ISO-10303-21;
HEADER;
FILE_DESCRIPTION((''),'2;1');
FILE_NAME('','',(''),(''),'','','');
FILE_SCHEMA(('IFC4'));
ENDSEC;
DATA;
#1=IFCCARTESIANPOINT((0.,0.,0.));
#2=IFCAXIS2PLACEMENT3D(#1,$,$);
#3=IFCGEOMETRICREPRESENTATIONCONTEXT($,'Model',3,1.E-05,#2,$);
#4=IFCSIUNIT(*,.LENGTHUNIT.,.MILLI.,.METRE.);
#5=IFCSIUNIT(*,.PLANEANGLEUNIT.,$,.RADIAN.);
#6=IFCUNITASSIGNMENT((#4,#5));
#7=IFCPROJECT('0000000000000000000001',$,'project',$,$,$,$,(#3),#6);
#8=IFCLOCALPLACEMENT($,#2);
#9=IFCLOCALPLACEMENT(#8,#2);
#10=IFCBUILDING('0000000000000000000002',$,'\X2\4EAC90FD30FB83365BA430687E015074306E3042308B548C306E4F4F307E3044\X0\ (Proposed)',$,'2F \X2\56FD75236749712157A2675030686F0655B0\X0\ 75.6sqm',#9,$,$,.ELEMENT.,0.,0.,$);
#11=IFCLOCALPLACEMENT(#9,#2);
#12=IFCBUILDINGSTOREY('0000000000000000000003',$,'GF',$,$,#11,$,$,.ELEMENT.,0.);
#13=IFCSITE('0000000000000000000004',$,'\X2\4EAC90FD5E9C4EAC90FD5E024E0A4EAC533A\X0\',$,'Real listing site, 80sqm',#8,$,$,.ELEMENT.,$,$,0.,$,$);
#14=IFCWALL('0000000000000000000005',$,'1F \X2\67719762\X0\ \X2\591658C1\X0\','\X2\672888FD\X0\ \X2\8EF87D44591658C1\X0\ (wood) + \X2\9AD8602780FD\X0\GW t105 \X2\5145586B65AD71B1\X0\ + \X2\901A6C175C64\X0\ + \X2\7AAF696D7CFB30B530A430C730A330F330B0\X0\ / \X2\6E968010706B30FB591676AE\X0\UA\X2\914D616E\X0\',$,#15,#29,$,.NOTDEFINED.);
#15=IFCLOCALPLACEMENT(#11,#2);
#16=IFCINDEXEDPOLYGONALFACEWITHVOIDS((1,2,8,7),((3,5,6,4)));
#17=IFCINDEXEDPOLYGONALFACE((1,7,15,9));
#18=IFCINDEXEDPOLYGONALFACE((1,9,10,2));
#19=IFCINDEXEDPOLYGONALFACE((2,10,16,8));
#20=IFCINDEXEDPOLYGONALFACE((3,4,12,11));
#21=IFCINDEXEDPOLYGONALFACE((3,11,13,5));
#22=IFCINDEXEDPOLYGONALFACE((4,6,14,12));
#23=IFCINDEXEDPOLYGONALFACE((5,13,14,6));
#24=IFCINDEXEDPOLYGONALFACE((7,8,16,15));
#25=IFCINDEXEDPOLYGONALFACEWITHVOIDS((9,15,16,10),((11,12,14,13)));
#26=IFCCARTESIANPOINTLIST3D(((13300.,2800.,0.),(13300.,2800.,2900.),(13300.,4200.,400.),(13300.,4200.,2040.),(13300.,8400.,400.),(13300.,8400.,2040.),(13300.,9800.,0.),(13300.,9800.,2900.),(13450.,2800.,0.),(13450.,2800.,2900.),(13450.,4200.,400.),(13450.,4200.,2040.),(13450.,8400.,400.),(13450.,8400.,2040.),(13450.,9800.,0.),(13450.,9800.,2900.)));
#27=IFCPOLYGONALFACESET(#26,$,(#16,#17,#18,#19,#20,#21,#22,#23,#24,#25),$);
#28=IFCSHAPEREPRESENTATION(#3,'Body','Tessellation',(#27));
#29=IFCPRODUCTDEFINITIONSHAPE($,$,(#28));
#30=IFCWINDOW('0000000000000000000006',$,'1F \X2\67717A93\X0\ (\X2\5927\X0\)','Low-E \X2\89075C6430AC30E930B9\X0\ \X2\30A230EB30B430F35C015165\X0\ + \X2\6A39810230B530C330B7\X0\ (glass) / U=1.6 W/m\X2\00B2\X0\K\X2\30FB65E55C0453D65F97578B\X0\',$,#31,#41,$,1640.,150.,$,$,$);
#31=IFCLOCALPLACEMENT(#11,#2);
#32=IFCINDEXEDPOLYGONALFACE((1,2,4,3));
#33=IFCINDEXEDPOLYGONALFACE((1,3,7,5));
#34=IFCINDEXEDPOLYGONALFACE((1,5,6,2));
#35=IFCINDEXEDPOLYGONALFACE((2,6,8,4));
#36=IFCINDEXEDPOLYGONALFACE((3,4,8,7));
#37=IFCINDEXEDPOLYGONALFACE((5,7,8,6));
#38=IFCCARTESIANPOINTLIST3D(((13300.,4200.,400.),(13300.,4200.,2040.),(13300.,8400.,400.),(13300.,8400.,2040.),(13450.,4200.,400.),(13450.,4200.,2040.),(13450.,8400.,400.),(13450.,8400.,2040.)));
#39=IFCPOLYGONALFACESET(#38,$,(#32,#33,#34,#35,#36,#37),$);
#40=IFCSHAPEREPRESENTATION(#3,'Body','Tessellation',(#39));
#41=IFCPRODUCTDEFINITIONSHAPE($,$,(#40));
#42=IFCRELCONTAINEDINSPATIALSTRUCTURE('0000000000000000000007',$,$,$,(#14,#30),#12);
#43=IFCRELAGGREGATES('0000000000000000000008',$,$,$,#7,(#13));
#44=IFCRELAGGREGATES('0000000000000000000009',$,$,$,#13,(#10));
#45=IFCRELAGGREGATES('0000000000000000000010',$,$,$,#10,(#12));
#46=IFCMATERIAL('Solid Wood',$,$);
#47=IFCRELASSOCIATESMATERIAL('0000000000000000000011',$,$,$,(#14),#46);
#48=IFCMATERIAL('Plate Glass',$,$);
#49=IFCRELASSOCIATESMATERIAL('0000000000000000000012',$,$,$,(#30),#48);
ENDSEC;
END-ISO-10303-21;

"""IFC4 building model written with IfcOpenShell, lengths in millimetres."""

from ifc_helpers import new_model, si_unit, frame, frame_2d, origin, place, context, project, spatial, rectangle, extrude, material, element, fill, save


model = new_model("IFC4")

# Units and contexts
model_context = context("Model", 3, precision=1e-05, world=origin())
ifc_project = project(units=[si_unit("LENGTHUNIT", "METRE", prefix="MILLI"), si_unit("PLANEANGLEUNIT", "RADIAN")], contexts=[model_context])

# Site, building, storey
site_placement = place(None, origin())
site = spatial("IfcSite", under=ifc_project, at=site_placement, Name="京都府京都市上京区", ObjectType="Real listing site, 80sqm", CompositionType="ELEMENT", RefElevation=0.0)
building_placement = place(site_placement, origin())
building = spatial("IfcBuilding", under=site, at=building_placement, Name="京都・茶室と縁側のある和の住まい (Proposed)", ObjectType="2F 国産杉無垢材と漆喰 75.6sqm", CompositionType="ELEMENT", ElevationOfRefHeight=0.0, ElevationOfTerrain=0.0)
storey_placement = place(building_placement, origin())
storey = spatial("IfcBuildingStorey", under=building, at=storey_placement, Name="GF", CompositionType="ELEMENT", Elevation=0.0)

# Shared definitions
ifc_material_1 = material(Name="Solid Wood")

# Wall, opening, window
wall_1_placement = place(storey_placement, frame((6650.0, 1400.0, 0.0)))
wall_1 = element("IfcWall", 1, at=wall_1_placement, inside=storey, material=ifc_material_1, Name="1F 東面 外壁", Description="木製 軸組外壁 (wood) + 高性能GW t105 充填断熱 + 通気層 + 窯業系サイディング / 準耐火・外皮UA配慮", PredefinedType="NOTDEFINED", context=model_context, shape_type="SweptSolid", body=[
    extrude(rectangle(XDim=150.0, YDim=7000.0, at=frame_2d((75.0, 3500.0))), frame((6650.0, 1400.0, 0.0)), (0.0, 0.0, 1.0), 2900.0),
])
opening_1_placement = place(storey_placement, frame((6650.0, 2100.0, 200.0)))
opening_1 = element("IfcOpeningElement", 2, at=opening_1_placement, cuts=wall_1, PredefinedType="NOTDEFINED", context=model_context, shape_type="SweptSolid", body=[
    extrude(rectangle(XDim=150.0, YDim=4200.0, at=frame_2d((75.0, 2100.0))), frame((6650.0, 2100.0, 200.0)), (0.0, 0.0, 1.0), 1640.0),
])
ifc_material_2 = material(Name="Plate Glass")
window_1_placement = place(storey_placement, frame((6650.0, 2100.0, 200.0)))
window_1 = element("IfcWindow", 3, at=window_1_placement, inside=storey, material=ifc_material_2, Name="1F 東窓 (大)", Description="Low-E 複層ガラス アルゴン封入 + 樹脂サッシ (glass) / U=1.6 W/m²K・日射取得型", OverallHeight=1640.0, OverallWidth=150.0, context=model_context, shape_type="SweptSolid", body=[
    extrude(rectangle(XDim=150.0, YDim=4200.0, at=frame_2d((75.0, 2100.0))), frame((6650.0, 2100.0, 200.0)), (0.0, 0.0, 1.0), 1640.0),
])
fill(opening_1, window_1)

save(model, "model.ifc")
